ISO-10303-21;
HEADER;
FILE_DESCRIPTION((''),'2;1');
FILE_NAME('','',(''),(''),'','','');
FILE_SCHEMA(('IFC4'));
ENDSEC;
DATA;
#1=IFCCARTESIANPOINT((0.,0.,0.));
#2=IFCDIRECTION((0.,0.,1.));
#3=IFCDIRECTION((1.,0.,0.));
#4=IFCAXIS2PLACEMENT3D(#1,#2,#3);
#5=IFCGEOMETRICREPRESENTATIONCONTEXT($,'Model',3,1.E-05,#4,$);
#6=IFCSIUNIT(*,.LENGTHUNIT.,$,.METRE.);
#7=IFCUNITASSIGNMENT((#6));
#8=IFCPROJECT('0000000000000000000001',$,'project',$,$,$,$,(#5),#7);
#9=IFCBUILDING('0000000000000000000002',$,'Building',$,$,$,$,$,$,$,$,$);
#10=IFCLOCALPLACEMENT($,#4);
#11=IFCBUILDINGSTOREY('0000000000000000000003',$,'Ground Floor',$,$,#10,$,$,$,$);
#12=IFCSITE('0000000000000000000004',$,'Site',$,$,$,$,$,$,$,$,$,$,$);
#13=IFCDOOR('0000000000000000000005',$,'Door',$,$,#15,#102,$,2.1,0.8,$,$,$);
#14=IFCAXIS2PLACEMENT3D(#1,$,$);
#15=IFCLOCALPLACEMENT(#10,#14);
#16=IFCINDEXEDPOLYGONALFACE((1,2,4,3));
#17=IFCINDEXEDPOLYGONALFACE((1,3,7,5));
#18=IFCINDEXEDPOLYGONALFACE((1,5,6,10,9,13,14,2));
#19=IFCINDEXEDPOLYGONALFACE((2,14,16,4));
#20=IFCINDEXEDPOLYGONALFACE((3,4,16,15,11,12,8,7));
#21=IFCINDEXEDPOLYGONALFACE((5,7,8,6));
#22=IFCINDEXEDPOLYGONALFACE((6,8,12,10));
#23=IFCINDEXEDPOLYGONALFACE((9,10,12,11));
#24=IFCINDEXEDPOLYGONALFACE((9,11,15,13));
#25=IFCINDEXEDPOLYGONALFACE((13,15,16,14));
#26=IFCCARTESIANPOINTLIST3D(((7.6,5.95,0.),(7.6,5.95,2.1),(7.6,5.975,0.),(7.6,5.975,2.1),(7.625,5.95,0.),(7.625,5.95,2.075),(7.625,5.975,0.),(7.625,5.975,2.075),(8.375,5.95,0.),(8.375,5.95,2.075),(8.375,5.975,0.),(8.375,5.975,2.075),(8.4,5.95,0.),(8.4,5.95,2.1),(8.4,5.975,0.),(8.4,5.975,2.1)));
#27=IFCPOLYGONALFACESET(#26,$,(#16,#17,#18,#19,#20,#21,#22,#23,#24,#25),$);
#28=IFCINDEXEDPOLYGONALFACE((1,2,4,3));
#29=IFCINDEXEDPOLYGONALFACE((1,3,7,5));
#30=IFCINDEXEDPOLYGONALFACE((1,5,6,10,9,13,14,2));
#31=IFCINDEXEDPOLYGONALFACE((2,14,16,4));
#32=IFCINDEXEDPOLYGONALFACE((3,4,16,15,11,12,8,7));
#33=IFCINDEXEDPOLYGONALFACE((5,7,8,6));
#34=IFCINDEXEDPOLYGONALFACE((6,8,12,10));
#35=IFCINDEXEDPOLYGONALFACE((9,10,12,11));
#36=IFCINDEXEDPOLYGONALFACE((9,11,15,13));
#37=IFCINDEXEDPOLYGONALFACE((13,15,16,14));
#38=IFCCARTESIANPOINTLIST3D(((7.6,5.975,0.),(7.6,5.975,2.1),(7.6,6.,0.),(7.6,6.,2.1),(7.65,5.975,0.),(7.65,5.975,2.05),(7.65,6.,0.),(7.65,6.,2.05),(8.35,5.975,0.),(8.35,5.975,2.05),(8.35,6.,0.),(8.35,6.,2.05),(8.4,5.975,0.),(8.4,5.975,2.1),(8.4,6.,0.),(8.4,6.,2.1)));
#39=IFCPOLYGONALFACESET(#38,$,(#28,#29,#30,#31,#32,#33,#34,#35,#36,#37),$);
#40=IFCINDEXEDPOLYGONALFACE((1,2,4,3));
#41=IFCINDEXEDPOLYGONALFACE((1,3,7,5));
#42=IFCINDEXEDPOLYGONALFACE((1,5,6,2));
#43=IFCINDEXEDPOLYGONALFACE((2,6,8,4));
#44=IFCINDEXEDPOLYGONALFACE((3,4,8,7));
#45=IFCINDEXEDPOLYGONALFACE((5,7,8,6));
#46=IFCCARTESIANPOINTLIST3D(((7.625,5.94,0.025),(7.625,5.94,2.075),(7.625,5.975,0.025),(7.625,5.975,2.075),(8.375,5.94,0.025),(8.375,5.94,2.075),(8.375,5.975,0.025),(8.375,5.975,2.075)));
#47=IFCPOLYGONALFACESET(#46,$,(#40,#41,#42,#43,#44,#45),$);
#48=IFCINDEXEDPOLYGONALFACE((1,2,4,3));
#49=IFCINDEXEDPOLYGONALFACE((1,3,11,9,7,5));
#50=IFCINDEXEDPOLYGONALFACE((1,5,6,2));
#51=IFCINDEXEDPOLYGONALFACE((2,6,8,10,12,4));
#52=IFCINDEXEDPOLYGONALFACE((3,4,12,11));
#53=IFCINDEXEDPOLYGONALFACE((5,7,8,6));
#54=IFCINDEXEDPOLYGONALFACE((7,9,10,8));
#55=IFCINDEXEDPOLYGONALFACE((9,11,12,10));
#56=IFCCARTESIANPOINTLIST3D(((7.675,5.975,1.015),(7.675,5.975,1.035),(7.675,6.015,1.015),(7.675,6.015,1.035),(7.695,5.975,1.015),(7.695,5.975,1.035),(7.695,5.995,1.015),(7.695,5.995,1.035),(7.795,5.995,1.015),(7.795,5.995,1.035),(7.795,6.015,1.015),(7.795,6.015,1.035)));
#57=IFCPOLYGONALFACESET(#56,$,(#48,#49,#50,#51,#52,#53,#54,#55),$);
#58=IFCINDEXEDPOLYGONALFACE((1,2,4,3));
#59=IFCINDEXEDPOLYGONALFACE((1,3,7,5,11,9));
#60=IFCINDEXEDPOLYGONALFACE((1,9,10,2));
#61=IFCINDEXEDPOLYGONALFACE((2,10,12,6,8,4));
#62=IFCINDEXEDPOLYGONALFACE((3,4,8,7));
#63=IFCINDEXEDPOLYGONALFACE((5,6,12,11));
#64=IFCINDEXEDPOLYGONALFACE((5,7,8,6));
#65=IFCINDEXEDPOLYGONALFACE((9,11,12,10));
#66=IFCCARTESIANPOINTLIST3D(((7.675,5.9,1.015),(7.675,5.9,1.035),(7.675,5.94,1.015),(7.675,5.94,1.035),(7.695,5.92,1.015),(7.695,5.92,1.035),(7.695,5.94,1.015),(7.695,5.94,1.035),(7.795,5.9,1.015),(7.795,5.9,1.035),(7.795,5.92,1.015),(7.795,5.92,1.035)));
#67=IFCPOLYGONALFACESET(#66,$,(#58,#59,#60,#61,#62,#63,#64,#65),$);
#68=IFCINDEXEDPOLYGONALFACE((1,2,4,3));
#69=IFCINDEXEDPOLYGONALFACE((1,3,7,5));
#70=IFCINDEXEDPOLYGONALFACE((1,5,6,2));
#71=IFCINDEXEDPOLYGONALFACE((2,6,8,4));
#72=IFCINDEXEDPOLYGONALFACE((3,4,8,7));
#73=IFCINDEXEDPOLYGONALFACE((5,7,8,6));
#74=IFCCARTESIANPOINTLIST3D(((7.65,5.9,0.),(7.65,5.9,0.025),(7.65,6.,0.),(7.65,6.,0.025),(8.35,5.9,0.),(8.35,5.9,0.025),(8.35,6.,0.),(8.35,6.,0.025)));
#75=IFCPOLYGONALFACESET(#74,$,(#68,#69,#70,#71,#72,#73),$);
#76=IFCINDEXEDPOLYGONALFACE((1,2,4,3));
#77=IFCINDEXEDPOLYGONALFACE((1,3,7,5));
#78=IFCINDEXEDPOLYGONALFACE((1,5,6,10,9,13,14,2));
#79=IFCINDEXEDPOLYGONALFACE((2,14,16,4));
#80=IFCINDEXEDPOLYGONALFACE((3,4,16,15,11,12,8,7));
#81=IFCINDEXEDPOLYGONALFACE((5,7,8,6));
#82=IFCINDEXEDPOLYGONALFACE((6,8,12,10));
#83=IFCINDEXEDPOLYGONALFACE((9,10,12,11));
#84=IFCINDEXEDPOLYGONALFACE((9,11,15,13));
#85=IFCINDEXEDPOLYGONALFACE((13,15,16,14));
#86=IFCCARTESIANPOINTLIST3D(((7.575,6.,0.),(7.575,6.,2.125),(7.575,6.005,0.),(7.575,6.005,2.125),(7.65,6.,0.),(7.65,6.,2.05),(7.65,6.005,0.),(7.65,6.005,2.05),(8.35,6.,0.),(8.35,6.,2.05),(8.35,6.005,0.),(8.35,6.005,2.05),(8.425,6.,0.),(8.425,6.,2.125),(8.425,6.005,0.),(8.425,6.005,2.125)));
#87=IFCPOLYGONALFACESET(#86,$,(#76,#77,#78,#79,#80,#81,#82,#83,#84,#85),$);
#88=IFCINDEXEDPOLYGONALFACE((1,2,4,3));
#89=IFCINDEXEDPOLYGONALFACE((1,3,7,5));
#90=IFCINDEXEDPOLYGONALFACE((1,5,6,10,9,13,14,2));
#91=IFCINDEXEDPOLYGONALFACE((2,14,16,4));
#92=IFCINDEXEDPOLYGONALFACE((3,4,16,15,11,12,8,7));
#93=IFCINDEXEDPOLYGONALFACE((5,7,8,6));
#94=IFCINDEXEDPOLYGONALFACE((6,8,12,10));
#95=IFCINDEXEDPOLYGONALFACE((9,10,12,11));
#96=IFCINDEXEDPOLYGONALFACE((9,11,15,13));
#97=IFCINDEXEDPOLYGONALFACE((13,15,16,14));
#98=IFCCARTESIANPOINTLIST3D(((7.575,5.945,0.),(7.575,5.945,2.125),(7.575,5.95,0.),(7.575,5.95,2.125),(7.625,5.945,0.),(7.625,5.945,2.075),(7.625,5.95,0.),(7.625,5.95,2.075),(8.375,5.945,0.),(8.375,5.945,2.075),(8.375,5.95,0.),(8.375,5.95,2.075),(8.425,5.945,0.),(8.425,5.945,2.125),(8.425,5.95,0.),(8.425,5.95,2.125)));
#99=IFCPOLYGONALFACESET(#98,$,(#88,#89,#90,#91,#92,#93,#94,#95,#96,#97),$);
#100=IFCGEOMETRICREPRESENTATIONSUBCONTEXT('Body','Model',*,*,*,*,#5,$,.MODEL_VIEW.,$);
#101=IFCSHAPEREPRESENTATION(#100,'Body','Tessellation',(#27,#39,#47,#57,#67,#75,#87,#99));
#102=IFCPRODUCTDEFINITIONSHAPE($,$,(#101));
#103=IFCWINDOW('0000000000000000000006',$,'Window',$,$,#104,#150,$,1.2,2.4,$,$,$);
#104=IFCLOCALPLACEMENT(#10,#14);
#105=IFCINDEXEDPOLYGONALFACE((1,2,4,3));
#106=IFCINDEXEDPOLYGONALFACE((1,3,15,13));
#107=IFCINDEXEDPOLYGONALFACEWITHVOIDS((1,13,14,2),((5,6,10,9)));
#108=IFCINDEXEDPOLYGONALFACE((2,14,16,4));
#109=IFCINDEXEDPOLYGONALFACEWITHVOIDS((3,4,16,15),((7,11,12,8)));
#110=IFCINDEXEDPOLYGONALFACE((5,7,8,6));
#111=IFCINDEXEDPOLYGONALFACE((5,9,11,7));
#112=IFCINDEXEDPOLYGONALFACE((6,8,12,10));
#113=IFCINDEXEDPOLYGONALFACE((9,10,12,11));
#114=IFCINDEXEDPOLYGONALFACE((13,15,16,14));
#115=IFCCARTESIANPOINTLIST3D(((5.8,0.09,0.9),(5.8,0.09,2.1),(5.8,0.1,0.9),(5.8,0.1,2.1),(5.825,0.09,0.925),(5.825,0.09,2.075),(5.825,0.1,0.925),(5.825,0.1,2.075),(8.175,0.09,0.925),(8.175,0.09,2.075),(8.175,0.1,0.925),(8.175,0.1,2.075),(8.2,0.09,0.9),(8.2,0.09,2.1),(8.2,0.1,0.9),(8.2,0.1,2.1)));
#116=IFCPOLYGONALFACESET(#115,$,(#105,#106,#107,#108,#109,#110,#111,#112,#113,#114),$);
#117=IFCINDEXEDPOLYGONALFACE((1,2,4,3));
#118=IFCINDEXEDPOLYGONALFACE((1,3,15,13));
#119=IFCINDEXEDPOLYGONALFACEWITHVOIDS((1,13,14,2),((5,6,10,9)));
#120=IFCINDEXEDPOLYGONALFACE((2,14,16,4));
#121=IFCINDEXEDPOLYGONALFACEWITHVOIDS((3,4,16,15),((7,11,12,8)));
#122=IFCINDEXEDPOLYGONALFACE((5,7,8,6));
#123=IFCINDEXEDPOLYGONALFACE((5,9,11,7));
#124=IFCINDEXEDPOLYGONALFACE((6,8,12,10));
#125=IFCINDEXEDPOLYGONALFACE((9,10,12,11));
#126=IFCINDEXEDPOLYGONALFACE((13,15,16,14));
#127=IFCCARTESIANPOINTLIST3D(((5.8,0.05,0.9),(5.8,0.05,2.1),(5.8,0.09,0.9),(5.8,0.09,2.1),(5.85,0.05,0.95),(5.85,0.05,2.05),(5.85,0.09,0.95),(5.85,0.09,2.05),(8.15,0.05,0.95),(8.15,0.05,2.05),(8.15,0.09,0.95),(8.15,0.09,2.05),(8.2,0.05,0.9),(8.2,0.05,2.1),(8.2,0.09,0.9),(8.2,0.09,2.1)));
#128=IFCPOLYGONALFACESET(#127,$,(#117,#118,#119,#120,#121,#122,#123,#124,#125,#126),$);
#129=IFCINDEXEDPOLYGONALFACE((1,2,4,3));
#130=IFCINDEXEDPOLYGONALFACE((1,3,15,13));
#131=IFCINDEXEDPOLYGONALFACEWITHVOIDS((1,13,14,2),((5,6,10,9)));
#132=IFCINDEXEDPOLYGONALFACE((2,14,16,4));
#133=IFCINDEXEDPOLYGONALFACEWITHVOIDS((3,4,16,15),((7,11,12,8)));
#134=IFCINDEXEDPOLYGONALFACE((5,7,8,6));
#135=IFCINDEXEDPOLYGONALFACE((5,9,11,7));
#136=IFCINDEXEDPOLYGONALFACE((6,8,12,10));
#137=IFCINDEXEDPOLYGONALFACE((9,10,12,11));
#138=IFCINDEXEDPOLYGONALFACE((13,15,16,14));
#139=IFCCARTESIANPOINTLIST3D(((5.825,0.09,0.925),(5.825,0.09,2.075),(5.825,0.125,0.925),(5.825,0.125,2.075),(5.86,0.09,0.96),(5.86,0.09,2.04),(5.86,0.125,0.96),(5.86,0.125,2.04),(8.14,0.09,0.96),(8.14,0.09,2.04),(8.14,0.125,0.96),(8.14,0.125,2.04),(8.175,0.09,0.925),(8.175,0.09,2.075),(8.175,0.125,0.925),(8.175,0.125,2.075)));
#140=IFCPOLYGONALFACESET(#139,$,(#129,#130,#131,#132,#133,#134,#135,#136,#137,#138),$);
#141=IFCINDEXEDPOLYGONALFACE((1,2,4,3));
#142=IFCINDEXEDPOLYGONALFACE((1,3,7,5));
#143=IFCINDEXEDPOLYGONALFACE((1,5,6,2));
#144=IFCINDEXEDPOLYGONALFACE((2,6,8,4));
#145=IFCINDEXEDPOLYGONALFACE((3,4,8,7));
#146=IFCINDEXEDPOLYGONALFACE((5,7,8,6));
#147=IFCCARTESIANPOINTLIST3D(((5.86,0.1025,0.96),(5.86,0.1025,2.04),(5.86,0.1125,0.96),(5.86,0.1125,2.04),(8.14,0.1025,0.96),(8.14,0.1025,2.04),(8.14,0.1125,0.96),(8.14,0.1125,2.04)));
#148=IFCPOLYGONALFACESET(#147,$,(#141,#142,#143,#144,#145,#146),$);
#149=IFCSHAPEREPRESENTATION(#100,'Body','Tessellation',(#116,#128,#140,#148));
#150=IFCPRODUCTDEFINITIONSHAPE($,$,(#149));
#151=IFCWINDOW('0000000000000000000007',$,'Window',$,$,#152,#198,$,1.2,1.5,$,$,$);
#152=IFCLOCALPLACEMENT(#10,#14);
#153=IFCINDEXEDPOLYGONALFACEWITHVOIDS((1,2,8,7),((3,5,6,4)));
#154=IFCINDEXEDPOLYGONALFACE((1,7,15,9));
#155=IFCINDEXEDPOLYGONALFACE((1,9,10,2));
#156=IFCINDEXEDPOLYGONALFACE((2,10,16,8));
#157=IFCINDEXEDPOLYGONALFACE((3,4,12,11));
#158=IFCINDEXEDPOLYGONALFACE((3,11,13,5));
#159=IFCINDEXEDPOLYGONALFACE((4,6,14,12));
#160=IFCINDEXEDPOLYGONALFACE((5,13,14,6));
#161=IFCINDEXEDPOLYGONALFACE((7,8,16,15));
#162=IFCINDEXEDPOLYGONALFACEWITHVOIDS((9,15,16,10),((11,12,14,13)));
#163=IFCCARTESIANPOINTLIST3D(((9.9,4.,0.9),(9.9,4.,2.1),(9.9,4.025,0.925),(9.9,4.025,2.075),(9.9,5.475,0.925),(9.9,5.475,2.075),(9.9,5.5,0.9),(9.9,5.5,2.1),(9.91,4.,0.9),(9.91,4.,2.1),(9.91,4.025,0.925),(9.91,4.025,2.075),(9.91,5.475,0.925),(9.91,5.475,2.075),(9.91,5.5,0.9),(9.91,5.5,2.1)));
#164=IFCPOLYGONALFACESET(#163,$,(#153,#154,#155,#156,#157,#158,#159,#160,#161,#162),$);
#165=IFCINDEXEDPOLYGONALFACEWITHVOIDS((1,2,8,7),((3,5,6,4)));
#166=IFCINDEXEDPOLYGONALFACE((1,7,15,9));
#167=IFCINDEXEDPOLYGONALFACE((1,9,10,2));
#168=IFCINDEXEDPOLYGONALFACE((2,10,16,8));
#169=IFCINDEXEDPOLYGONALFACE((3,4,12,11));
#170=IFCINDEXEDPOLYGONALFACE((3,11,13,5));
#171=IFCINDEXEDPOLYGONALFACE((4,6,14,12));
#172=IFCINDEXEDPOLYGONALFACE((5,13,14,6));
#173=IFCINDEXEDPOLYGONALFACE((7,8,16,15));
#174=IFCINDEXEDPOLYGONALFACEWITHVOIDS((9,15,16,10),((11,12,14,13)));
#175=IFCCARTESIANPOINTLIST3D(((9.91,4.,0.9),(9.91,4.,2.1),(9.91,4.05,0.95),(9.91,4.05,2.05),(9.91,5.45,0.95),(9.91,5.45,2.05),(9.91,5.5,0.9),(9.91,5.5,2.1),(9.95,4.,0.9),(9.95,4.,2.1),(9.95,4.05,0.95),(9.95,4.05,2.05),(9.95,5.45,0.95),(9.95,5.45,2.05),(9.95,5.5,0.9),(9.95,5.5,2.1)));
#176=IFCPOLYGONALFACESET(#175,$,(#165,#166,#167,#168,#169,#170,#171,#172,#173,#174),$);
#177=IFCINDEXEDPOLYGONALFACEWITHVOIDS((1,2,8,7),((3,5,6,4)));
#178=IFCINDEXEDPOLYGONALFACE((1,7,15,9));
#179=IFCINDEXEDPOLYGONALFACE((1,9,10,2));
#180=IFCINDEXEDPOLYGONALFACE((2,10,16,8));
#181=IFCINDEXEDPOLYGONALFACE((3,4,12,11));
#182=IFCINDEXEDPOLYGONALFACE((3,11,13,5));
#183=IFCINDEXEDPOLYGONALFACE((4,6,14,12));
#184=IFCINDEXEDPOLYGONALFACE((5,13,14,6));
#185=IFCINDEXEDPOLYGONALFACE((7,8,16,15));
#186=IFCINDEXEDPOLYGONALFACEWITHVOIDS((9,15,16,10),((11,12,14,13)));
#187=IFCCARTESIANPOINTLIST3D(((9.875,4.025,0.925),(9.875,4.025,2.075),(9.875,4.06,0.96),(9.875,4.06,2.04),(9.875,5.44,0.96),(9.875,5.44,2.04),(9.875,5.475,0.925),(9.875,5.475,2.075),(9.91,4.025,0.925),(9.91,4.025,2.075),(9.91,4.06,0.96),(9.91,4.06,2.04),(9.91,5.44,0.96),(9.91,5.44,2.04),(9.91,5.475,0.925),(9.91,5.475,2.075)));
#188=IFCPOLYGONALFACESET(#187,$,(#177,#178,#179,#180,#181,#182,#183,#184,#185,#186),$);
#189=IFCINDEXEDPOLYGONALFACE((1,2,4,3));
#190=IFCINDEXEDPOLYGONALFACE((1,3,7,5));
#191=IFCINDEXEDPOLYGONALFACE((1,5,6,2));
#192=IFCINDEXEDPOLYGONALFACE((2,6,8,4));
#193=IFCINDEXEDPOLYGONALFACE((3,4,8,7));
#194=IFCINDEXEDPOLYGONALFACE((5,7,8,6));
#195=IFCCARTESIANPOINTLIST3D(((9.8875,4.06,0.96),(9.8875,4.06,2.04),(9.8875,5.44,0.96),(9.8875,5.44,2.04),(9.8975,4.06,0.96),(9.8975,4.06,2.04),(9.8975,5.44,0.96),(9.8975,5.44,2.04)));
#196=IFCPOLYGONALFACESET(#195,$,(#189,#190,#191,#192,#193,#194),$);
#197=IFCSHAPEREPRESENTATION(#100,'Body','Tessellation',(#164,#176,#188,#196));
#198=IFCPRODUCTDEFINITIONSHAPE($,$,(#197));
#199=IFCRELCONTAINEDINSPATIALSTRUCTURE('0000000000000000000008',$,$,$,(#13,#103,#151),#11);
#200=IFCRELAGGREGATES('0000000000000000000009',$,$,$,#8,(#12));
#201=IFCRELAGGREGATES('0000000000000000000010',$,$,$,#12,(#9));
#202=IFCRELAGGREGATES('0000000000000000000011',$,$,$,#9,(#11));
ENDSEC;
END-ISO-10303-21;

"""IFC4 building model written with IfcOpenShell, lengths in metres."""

from ifc_helpers import new_model, si_unit, frame, origin_with_axes, place, context, subcontext, project, spatial, line, indexed_curve, outline, extrude, element, save


model = new_model("IFC4")

# Units and contexts
model_context = context("Model", 3, precision=1e-05, world=origin_with_axes())
body_context = subcontext(model_context, "Body", "Model", "MODEL_VIEW")
ifc_project = project(units=[si_unit("LENGTHUNIT", "METRE")], contexts=[model_context])

# Site, building, storey
site = spatial("IfcSite", under=ifc_project, Name="Site")
building = spatial("IfcBuilding", under=site, Name="Building")
storey_placement = place(None, origin_with_axes())
storey = spatial("IfcBuildingStorey", under=building, at=storey_placement, Name="Ground Floor")

# Door
door_1_placement = place(storey_placement, frame((8.4, 6.0, 0.0), z_axis=(0.0, 0.0, 1.0), x_axis=(-1.0, 0.0, 0.0)))
element("IfcDoor", 1, at=door_1_placement, inside=storey, Name="Door", OverallHeight=2.1, OverallWidth=0.8, context=body_context, shape_type="SweptSolid", body=[
    extrude(outline(indexed_curve([(0.0, 0.0), (0.0, 2.1), (0.8, 2.1), (0.8, 0.0), (0.775, 0.0), (0.775, 2.075), (0.025, 2.075), (0.025, 0.0)], segments=[line(1, 2, 3, 4, 5, 6, 7, 8, 1)])), frame((0.0, 0.025, 0.0), z_axis=(0.0, -1.0, 0.0), x_axis=(1.0, 0.0, 0.0)), (0.0, 0.0, -1.0), 0.025),
    extrude(outline(indexed_curve([(0.0, 0.0), (0.0, 2.1), (0.8, 2.1), (0.8, 0.0), (0.75, 0.0), (0.75, 2.05), (0.05, 2.05), (0.05, 0.0)], segments=[line(1, 2, 3, 4, 5, 6, 7, 8, 1)])), frame((0.0, 0.0, 0.0), z_axis=(0.0, -1.0, 0.0), x_axis=(1.0, 0.0, 0.0)), (0.0, 0.0, -1.0), 0.025),
    extrude(outline(indexed_curve([(0.0, 0.0), (0.75, 0.0), (0.75, 0.035), (0.0, 0.035)], segments=[line(1, 2, 3, 4, 1)])), frame((0.025, 0.025, 0.025), z_axis=(0.0, 0.0, 1.0), x_axis=(1.0, 0.0, 0.0)), (0.0, 0.0, 1.0), 2.05),
    extrude(outline(indexed_curve([(0.0, 0.0), (0.0, -0.04), (-0.12, -0.04), (-0.12, -0.02), (-0.02, -0.02), (-0.02, 0.0)], segments=[line(1, 2, 3, 4, 5, 6, 1)])), frame((0.725, 0.025, 1.015), z_axis=(0.0, 0.0, 1.0), x_axis=(1.0, 0.0, 0.0)), (0.0, 0.0, 1.0), 0.02),
    extrude(outline(indexed_curve([(0.0, 0.0), (0.0, 0.04), (-0.12, 0.04), (-0.12, 0.02), (-0.02, 0.02), (-0.02, 0.0)], segments=[line(1, 2, 3, 4, 5, 6, 1)])), frame((0.725, 0.06, 1.015), z_axis=(0.0, 0.0, 1.0), x_axis=(1.0, 0.0, 0.0)), (0.0, 0.0, 1.0), 0.02),
    extrude(outline(indexed_curve([(0.0, 0.0), (0.7, 0.0), (0.7, 0.1), (0.0, 0.1)], segments=[line(1, 2, 3, 4, 1)])), frame((0.05, 0.0, 0.0), z_axis=(0.0, 0.0, 1.0), x_axis=(1.0, 0.0, 0.0)), (0.0, 0.0, 1.0), 0.025),
    extrude(outline(indexed_curve([(0.0, 0.0), (0.0, 2.125), (0.85, 2.125), (0.85, 0.0), (0.775, 0.0), (0.775, 2.05), (0.075, 2.05), (0.075, 0.0)], segments=[line(1, 2, 3, 4, 5, 6, 7, 8, 1)])), frame((-0.025, -0.005, 0.0), z_axis=(0.0, -1.0, 0.0), x_axis=(1.0, 0.0, 0.0)), (0.0, 0.0, -1.0), 0.005),
    extrude(outline(indexed_curve([(0.0, 0.0), (0.0, 2.125), (0.85, 2.125), (0.85, 0.0), (0.8, 0.0), (0.8, 2.075), (0.05, 2.075), (0.05, 0.0)], segments=[line(1, 2, 3, 4, 5, 6, 7, 8, 1)])), frame((-0.025, 0.05, 0.0), z_axis=(0.0, -1.0, 0.0), x_axis=(1.0, 0.0, 0.0)), (0.0, 0.0, -1.0), 0.005),
])

# Windows
window_1_placement = place(storey_placement, frame((5.8, 0.0, 0.9), z_axis=(0.0, 0.0, 1.0), x_axis=(1.0, 0.0, 0.0)))
element("IfcWindow", 2, at=window_1_placement, inside=storey, Name="Window", OverallHeight=1.2, OverallWidth=2.4, context=body_context, shape_type="SweptSolid", body=[
    extrude(outline(indexed_curve([(0.0, 0.0), (2.4, 0.0), (2.4, 1.2), (0.0, 1.2)], segments=[line(1, 2, 3, 4, 1)]), holes=[indexed_curve([(0.025, 0.025), (2.375, 0.025), (2.375, 1.175), (0.025, 1.175)], segments=[line(1, 2, 3, 4, 1)])]), frame((0.0, 0.09, 0.0), z_axis=(0.0, -1.0, 0.0), x_axis=(1.0, 0.0, 0.0)), (0.0, 0.0, -1.0), 0.01),
    extrude(outline(indexed_curve([(0.0, 0.0), (2.4, 0.0), (2.4, 1.2), (0.0, 1.2)], segments=[line(1, 2, 3, 4, 1)]), holes=[indexed_curve([(0.05, 0.05), (2.35, 0.05), (2.35, 1.15), (0.05, 1.15)], segments=[line(1, 2, 3, 4, 1)])]), frame((0.0, 0.05, 0.0), z_axis=(0.0, -1.0, 0.0), x_axis=(1.0, 0.0, 0.0)), (0.0, 0.0, -1.0), 0.04),
    extrude(outline(indexed_curve([(0.0, 0.0), (2.35, 0.0), (2.35, 1.15), (0.0, 1.15)], segments=[line(1, 2, 3, 4, 1)]), holes=[indexed_curve([(0.035, 0.035), (2.315, 0.035), (2.315, 1.115), (0.035, 1.115)], segments=[line(1, 2, 3, 4, 1)])]), frame((0.025, 0.09, 0.025), z_axis=(0.0, -1.0, 0.0), x_axis=(1.0, 0.0, 0.0)), (0.0, 0.0, -1.0), 0.035),
    extrude(outline(indexed_curve([(0.035, 0.035), (2.315, 0.035), (2.315, 1.115), (0.035, 1.115)], segments=[line(1, 2, 3, 4, 1)])), frame((0.025, 0.1025, 0.025), z_axis=(0.0, -1.0, 0.0), x_axis=(1.0, 0.0, 0.0)), (0.0, 0.0, -1.0), 0.01),
])
window_2_placement = place(storey_placement, frame((10.0, 4.0, 0.9), z_axis=(0.0, 0.0, 1.0), x_axis=(0.0, 1.0, 0.0)))
element("IfcWindow", 3, at=window_2_placement, inside=storey, Name="Window", OverallHeight=1.2, OverallWidth=1.5, context=body_context, shape_type="SweptSolid", body=[
    extrude(outline(indexed_curve([(0.0, 0.0), (1.5, 0.0), (1.5, 1.2), (0.0, 1.2)], segments=[line(1, 2, 3, 4, 1)]), holes=[indexed_curve([(0.025, 0.025), (1.475, 0.025), (1.475, 1.175), (0.025, 1.175)], segments=[line(1, 2, 3, 4, 1)])]), frame((0.0, 0.09, 0.0), z_axis=(0.0, -1.0, 0.0), x_axis=(1.0, 0.0, 0.0)), (0.0, 0.0, -1.0), 0.01),
    extrude(outline(indexed_curve([(0.0, 0.0), (1.5, 0.0), (1.5, 1.2), (0.0, 1.2)], segments=[line(1, 2, 3, 4, 1)]), holes=[indexed_curve([(0.05, 0.05), (1.45, 0.05), (1.45, 1.15), (0.05, 1.15)], segments=[line(1, 2, 3, 4, 1)])]), frame((0.0, 0.05, 0.0), z_axis=(0.0, -1.0, 0.0), x_axis=(1.0, 0.0, 0.0)), (0.0, 0.0, -1.0), 0.04),
    extrude(outline(indexed_curve([(0.0, 0.0), (1.45, 0.0), (1.45, 1.15), (0.0, 1.15)], segments=[line(1, 2, 3, 4, 1)]), holes=[indexed_curve([(0.035, 0.035), (1.415, 0.035), (1.415, 1.115), (0.035, 1.115)], segments=[line(1, 2, 3, 4, 1)])]), frame((0.025, 0.09, 0.025), z_axis=(0.0, -1.0, 0.0), x_axis=(1.0, 0.0, 0.0)), (0.0, 0.0, -1.0), 0.035),
    extrude(outline(indexed_curve([(0.035, 0.035), (1.415, 0.035), (1.415, 1.115), (0.035, 1.115)], segments=[line(1, 2, 3, 4, 1)])), frame((0.025, 0.1025, 0.025), z_axis=(0.0, -1.0, 0.0), x_axis=(1.0, 0.0, 0.0)), (0.0, 0.0, -1.0), 0.01),
])

save(model, "model.ifc")
